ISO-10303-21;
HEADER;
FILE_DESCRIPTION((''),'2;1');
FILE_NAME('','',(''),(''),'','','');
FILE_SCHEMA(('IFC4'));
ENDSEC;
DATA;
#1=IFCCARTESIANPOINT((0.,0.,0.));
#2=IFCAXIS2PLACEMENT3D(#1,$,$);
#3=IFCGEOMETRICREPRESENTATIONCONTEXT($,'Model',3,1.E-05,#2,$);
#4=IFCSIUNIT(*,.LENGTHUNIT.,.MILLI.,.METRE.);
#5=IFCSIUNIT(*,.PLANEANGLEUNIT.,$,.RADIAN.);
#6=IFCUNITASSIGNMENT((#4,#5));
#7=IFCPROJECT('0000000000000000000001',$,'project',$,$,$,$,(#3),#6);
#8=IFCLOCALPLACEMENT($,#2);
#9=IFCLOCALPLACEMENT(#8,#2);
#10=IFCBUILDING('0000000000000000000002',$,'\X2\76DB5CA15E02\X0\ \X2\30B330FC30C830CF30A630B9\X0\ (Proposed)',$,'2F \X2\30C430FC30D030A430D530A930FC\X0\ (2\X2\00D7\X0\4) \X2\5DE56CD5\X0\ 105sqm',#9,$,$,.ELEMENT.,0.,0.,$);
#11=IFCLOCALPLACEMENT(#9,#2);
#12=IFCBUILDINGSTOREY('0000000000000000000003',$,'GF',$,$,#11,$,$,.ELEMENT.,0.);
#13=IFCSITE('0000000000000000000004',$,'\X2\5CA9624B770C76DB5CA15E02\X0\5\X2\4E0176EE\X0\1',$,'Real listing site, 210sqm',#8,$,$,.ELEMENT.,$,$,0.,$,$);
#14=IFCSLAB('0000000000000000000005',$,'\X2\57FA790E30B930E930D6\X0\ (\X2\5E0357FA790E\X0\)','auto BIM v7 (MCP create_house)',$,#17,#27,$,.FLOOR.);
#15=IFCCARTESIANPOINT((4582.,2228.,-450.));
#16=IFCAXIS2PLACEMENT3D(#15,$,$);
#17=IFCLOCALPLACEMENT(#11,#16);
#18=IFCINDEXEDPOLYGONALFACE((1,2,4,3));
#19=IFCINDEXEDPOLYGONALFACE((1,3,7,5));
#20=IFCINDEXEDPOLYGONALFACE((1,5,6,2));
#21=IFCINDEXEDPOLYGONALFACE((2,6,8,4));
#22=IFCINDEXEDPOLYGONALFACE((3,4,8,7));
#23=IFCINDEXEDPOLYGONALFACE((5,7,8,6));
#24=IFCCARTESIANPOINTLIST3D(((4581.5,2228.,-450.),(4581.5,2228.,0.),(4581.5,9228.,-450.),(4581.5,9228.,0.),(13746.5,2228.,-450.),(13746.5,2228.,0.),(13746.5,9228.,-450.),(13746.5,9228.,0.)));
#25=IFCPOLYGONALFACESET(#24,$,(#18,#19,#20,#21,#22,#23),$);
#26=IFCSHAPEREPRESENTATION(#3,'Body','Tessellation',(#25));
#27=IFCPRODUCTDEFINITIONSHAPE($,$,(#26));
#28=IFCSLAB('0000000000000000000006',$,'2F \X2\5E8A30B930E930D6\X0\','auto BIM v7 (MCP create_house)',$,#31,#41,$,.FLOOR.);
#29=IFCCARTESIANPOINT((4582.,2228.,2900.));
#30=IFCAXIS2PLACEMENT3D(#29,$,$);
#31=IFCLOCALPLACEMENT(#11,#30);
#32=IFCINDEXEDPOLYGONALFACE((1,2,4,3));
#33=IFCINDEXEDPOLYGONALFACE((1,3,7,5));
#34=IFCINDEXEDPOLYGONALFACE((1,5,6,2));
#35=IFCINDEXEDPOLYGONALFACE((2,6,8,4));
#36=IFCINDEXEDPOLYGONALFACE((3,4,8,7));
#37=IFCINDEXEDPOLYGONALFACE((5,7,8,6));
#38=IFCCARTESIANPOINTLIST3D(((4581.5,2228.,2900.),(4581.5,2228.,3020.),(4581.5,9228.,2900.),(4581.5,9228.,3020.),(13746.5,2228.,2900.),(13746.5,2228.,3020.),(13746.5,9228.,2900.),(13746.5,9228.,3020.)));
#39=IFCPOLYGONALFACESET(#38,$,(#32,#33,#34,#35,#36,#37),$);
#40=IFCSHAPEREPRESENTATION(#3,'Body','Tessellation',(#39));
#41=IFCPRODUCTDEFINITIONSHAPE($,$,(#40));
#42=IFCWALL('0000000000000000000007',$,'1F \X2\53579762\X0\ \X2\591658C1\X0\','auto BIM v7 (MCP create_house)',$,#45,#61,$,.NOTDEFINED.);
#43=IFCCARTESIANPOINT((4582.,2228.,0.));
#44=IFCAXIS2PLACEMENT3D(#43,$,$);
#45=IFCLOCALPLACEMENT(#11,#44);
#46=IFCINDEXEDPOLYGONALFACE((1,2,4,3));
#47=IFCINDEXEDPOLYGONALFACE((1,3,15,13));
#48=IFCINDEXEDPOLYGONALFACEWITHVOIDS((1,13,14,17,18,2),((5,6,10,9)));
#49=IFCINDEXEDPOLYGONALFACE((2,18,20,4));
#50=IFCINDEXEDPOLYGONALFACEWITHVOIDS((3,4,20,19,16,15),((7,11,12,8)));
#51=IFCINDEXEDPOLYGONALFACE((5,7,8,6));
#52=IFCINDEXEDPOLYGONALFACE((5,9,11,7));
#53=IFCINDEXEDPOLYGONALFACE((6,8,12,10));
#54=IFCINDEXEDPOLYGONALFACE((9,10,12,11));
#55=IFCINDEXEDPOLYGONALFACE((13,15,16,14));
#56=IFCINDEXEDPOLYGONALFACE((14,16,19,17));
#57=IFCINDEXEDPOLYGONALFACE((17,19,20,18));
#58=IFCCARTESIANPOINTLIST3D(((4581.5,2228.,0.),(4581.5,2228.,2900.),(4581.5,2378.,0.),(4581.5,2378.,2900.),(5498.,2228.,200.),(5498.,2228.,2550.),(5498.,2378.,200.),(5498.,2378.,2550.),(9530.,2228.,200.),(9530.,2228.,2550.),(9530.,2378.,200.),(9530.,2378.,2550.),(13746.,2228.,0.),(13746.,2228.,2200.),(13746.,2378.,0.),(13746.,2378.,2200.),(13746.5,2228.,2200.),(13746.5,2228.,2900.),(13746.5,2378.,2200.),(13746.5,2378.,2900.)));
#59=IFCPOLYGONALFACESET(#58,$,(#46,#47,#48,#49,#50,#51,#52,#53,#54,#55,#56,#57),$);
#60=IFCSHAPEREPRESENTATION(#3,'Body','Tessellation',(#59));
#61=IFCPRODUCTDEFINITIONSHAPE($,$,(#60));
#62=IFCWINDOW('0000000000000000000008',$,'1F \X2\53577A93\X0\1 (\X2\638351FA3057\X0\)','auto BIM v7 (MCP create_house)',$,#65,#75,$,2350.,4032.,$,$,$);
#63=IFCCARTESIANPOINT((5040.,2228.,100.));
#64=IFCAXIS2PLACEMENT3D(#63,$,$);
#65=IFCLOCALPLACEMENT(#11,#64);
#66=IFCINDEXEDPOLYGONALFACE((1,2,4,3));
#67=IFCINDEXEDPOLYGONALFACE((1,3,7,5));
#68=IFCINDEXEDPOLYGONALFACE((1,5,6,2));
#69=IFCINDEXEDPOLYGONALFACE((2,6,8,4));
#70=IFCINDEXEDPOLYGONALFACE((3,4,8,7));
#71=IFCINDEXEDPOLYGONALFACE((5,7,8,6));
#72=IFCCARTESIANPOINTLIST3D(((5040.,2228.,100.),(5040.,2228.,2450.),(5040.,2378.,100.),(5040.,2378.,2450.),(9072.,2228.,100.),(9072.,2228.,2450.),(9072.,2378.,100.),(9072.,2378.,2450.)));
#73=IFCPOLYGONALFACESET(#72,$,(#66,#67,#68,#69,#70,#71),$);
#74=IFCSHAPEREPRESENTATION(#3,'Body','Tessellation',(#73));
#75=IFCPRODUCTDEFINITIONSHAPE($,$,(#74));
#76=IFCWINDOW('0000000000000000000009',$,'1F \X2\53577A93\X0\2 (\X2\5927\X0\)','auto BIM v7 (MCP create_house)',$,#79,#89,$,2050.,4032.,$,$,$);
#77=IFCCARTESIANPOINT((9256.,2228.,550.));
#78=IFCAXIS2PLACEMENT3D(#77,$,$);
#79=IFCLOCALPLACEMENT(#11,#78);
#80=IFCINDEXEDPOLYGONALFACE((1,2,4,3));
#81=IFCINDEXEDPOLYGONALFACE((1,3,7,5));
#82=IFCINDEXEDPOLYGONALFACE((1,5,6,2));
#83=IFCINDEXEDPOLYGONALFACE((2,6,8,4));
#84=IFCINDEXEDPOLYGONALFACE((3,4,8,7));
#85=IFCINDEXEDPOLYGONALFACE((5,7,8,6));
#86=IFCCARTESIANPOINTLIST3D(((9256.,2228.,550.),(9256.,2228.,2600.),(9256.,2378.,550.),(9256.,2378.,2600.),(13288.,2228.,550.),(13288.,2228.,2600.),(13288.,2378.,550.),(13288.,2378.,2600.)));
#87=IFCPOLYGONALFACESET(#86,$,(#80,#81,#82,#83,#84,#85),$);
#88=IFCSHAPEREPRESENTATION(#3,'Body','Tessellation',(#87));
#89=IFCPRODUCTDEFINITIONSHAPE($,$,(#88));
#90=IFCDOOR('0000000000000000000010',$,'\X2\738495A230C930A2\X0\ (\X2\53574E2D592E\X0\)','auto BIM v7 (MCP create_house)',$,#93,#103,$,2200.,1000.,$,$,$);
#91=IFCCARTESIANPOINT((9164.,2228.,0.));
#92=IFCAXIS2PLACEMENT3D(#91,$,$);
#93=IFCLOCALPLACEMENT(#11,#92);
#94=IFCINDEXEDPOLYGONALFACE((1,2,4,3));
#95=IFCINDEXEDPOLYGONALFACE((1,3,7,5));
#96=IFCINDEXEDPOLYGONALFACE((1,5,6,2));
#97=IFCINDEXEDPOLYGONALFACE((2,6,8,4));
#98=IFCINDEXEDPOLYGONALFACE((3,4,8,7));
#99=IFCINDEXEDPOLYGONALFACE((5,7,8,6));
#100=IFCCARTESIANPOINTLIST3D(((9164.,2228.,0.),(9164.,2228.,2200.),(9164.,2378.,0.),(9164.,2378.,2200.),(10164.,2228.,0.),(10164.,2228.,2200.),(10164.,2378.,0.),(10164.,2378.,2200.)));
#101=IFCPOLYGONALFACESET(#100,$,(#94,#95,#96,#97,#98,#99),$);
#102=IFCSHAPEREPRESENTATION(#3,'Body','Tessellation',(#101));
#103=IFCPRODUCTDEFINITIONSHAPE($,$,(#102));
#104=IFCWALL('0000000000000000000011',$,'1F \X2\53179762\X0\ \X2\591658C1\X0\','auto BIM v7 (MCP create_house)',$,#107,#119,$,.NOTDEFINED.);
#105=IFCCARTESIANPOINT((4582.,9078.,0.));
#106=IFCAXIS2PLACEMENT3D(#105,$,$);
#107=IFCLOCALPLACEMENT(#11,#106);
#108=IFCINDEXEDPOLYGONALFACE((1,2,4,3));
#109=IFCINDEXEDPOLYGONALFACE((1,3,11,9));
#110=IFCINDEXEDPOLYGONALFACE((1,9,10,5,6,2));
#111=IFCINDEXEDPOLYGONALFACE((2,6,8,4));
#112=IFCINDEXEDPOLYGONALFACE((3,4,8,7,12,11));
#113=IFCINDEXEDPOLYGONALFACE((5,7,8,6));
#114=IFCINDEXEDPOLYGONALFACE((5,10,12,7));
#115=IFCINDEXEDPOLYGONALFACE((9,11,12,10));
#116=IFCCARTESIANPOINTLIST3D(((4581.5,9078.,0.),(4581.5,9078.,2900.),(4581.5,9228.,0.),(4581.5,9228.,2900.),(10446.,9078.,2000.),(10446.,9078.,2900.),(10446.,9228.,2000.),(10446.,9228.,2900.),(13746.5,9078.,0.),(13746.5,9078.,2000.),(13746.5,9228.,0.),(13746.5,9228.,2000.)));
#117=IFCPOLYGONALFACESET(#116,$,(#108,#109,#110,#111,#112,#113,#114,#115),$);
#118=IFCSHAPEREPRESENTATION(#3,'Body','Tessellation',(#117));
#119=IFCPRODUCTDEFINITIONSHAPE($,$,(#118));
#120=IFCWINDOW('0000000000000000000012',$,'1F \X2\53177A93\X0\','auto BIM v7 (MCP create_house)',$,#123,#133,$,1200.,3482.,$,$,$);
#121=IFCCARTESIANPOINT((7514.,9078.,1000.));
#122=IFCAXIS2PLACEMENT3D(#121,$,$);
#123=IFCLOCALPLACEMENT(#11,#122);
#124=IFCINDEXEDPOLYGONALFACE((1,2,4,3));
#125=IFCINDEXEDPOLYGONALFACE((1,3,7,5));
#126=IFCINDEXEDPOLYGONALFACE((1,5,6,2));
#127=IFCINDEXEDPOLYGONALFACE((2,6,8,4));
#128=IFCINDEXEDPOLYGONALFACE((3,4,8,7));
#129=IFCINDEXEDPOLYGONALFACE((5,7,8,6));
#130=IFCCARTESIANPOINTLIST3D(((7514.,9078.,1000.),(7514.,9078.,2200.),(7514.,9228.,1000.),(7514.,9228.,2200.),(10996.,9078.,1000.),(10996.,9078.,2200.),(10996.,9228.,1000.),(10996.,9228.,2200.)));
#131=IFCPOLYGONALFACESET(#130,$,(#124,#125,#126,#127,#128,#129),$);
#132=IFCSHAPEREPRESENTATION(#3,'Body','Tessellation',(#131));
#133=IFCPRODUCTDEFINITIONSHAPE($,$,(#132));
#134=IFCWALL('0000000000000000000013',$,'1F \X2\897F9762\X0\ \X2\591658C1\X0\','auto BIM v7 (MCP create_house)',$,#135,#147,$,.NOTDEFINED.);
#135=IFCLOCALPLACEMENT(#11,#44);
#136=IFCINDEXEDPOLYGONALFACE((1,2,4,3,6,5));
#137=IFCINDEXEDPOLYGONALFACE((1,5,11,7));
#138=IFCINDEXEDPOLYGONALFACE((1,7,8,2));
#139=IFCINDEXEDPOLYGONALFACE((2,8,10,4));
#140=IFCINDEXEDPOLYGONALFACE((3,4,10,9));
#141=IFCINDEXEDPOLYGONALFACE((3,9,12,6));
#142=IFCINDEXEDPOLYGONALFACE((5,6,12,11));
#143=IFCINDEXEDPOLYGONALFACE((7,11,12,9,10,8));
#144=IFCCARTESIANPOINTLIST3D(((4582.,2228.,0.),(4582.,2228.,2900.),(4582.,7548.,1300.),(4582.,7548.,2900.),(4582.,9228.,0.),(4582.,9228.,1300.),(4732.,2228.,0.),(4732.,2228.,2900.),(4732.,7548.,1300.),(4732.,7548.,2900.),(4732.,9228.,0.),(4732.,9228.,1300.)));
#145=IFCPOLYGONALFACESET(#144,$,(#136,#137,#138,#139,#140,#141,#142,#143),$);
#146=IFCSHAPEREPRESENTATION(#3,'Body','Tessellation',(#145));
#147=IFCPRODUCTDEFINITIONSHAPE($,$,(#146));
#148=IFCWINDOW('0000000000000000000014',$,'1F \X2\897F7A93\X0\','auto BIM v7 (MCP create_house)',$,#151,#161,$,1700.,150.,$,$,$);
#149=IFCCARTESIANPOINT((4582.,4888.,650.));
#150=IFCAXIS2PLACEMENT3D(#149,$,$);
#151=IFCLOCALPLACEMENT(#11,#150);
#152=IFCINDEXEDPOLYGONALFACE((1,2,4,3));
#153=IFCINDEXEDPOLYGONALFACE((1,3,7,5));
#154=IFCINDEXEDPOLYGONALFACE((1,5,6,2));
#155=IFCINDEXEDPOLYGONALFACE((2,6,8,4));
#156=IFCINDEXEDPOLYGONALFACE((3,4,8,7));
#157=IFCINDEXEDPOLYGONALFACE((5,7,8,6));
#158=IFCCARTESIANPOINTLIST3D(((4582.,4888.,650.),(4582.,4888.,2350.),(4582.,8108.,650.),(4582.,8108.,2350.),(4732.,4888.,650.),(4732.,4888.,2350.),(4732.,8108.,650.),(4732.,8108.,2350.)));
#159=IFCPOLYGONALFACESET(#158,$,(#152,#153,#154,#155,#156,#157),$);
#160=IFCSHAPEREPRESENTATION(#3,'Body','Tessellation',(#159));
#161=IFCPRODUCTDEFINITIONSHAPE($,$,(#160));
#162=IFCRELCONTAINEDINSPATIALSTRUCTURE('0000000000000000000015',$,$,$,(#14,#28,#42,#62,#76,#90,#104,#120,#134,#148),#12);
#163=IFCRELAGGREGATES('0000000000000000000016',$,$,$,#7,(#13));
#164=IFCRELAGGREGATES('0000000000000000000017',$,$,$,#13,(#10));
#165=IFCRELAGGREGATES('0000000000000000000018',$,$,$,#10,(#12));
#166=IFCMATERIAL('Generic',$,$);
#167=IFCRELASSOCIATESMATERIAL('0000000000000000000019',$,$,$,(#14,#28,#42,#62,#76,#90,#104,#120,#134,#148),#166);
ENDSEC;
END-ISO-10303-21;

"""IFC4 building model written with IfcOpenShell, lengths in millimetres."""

from ifc_helpers import new_model, si_unit, frame, frame_2d, origin, place, context, project, spatial, rectangle, extrude, material, element, fill, save


model = new_model("IFC4")

# Units and contexts
model_context = context("Model", 3, precision=1e-05, world=origin())
ifc_project = project(units=[si_unit("LENGTHUNIT", "METRE", prefix="MILLI"), si_unit("PLANEANGLEUNIT", "RADIAN")], contexts=[model_context])

# Site, building, storey
site_placement = place(None, origin())
site = spatial("IfcSite", under=ifc_project, at=site_placement, Name="岩手県盛岡市5丁目1", ObjectType="Real listing site, 210sqm", CompositionType="ELEMENT", RefElevation=0.0)
building_placement = place(site_placement, origin())
building = spatial("IfcBuilding", under=site, at=building_placement, Name="盛岡市 コートハウス (Proposed)", ObjectType="2F ツーバイフォー (2×4) 工法 105sqm", CompositionType="ELEMENT", ElevationOfRefHeight=0.0, ElevationOfTerrain=0.0)
storey_placement = place(building_placement, origin())
storey = spatial("IfcBuildingStorey", under=building, at=storey_placement, Name="GF", CompositionType="ELEMENT", Elevation=0.0)

# Slabs
ifc_material = material(Name="Generic")
slab_1_placement = place(storey_placement, frame((4582.0, 2228.0, -450.0)))
element("IfcSlab", 1, at=slab_1_placement, inside=storey, material=ifc_material, Name="基礎スラブ (布基礎)", Description="auto BIM v7 (MCP create_house)", PredefinedType="FLOOR", context=model_context, shape_type="SweptSolid", body=[
    extrude(rectangle(XDim=9165.0, YDim=7000.0, at=frame_2d((4582.0, 3500.0))), frame((4582.0, 2228.0, -450.0)), (0.0, 0.0, 1.0), 450.0),
])
slab_2_placement = place(storey_placement, frame((4582.0, 2228.0, 2900.0)))
element("IfcSlab", 2, at=slab_2_placement, inside=storey, material=ifc_material, Name="2F 床スラブ", Description="auto BIM v7 (MCP create_house)", PredefinedType="FLOOR", context=model_context, shape_type="SweptSolid", body=[
    extrude(rectangle(XDim=9165.0, YDim=7000.0, at=frame_2d((4582.0, 3500.0))), frame((4582.0, 2228.0, 2900.0)), (0.0, 0.0, 1.0), 120.0),
])

# Wall, openings, windows, door
wall_1_placement = place(storey_placement, frame((4582.0, 2228.0, 0.0)))
wall_1 = element("IfcWall", 3, at=wall_1_placement, inside=storey, material=ifc_material, Name="1F 南面 外壁", Description="auto BIM v7 (MCP create_house)", PredefinedType="NOTDEFINED", context=model_context, shape_type="SweptSolid", body=[
    extrude(rectangle(XDim=9165.0, YDim=150.0, at=frame_2d((4582.0, 75.0))), frame((4582.0, 2228.0, 0.0)), (0.0, 0.0, 1.0), 2900.0),
])
opening_1_placement = place(storey_placement, frame((5040.0, 2228.0, 100.0)))
opening_1 = element("IfcOpeningElement", 4, at=opening_1_placement, cuts=wall_1, PredefinedType="NOTDEFINED", context=model_context, shape_type="SweptSolid", body=[
    extrude(rectangle(XDim=4032.0, YDim=150.0, at=frame_2d((2016.0, 75.0))), frame((5040.0, 2228.0, 100.0)), (0.0, 0.0, 1.0), 2350.0),
])
opening_2_placement = place(storey_placement, frame((9256.0, 2228.0, 550.0)))
opening_2 = element("IfcOpeningElement", 5, at=opening_2_placement, cuts=wall_1, PredefinedType="NOTDEFINED", context=model_context, shape_type="SweptSolid", body=[
    extrude(rectangle(XDim=4032.0, YDim=150.0, at=frame_2d((2016.0, 75.0))), frame((9256.0, 2228.0, 550.0)), (0.0, 0.0, 1.0), 2050.0),
])
opening_3_placement = place(storey_placement, frame((9164.0, 2228.0, 0.0)))
opening_3 = element("IfcOpeningElement", 6, at=opening_3_placement, cuts=wall_1, PredefinedType="NOTDEFINED", context=model_context, shape_type="SweptSolid", body=[
    extrude(rectangle(XDim=1000.0, YDim=150.0, at=frame_2d((500.0, 75.0))), frame((9164.0, 2228.0, 0.0)), (0.0, 0.0, 1.0), 2200.0),
])
window_1_placement = place(storey_placement, frame((5040.0, 2228.0, 100.0)))
window_1 = element("IfcWindow", 7, at=window_1_placement, inside=storey, material=ifc_material, Name="1F 南窓1 (掃出し)", Description="auto BIM v7 (MCP create_house)", OverallHeight=2350.0, OverallWidth=4032.0, context=model_context, shape_type="SweptSolid", body=[
    extrude(rectangle(XDim=4032.0, YDim=150.0, at=frame_2d((2016.0, 75.0))), frame((5040.0, 2228.0, 100.0)), (0.0, 0.0, 1.0), 2350.0),
])
fill(opening_1, window_1)
window_2_placement = place(storey_placement, frame((9256.0, 2228.0, 550.0)))
window_2 = element("IfcWindow", 8, at=window_2_placement, inside=storey, material=ifc_material, Name="1F 南窓2 (大)", Description="auto BIM v7 (MCP create_house)", OverallHeight=2050.0, OverallWidth=4032.0, context=model_context, shape_type="SweptSolid", body=[
    extrude(rectangle(XDim=4032.0, YDim=150.0, at=frame_2d((2016.0, 75.0))), frame((9256.0, 2228.0, 550.0)), (0.0, 0.0, 1.0), 2050.0),
])
fill(opening_2, window_2)
door_placement = place(storey_placement, frame((9164.0, 2228.0, 0.0)))
door = element("IfcDoor", 9, at=door_placement, inside=storey, material=ifc_material, Name="玄関ドア (南中央)", Description="auto BIM v7 (MCP create_house)", OverallHeight=2200.0, OverallWidth=1000.0, context=model_context, shape_type="SweptSolid", body=[
    extrude(rectangle(XDim=1000.0, YDim=150.0, at=frame_2d((500.0, 75.0))), frame((9164.0, 2228.0, 0.0)), (0.0, 0.0, 1.0), 2200.0),
])
fill(opening_3, door)

# Walls, openings, windows
wall_2_placement = place(storey_placement, frame((4582.0, 9078.0, 0.0)))
wall_2 = element("IfcWall", 10, at=wall_2_placement, inside=storey, material=ifc_material, Name="1F 北面 外壁", Description="auto BIM v7 (MCP create_house)", PredefinedType="NOTDEFINED", context=model_context, shape_type="SweptSolid", body=[
    extrude(rectangle(XDim=9165.0, YDim=150.0, at=frame_2d((4582.0, 75.0))), frame((4582.0, 9078.0, 0.0)), (0.0, 0.0, 1.0), 2900.0),
])
opening_4_placement = place(storey_placement, frame((7514.0, 9078.0, 1000.0)))
opening_4 = element("IfcOpeningElement", 11, at=opening_4_placement, cuts=wall_2, PredefinedType="NOTDEFINED", context=model_context, shape_type="SweptSolid", body=[
    extrude(rectangle(XDim=3482.0, YDim=150.0, at=frame_2d((1741.0, 75.0))), frame((7514.0, 9078.0, 1000.0)), (0.0, 0.0, 1.0), 1200.0),
])
window_3_placement = place(storey_placement, frame((7514.0, 9078.0, 1000.0)))
window_3 = element("IfcWindow", 12, at=window_3_placement, inside=storey, material=ifc_material, Name="1F 北窓", Description="auto BIM v7 (MCP create_house)", OverallHeight=1200.0, OverallWidth=3482.0, context=model_context, shape_type="SweptSolid", body=[
    extrude(rectangle(XDim=3482.0, YDim=150.0, at=frame_2d((1741.0, 75.0))), frame((7514.0, 9078.0, 1000.0)), (0.0, 0.0, 1.0), 1200.0),
])
fill(opening_4, window_3)
wall_3_placement = place(storey_placement, frame((4582.0, 2228.0, 0.0)))
wall_3 = element("IfcWall", 13, at=wall_3_placement, inside=storey, material=ifc_material, Name="1F 西面 外壁", Description="auto BIM v7 (MCP create_house)", PredefinedType="NOTDEFINED", context=model_context, shape_type="SweptSolid", body=[
    extrude(rectangle(XDim=150.0, YDim=7000.0, at=frame_2d((75.0, 3500.0))), frame((4582.0, 2228.0, 0.0)), (0.0, 0.0, 1.0), 2900.0),
])
opening_5_placement = place(storey_placement, frame((4582.0, 4888.0, 650.0)))
opening_5 = element("IfcOpeningElement", 14, at=opening_5_placement, cuts=wall_3, PredefinedType="NOTDEFINED", context=model_context, shape_type="SweptSolid", body=[
    extrude(rectangle(XDim=150.0, YDim=3220.0, at=frame_2d((75.0, 1610.0))), frame((4582.0, 4888.0, 650.0)), (0.0, 0.0, 1.0), 1700.0),
])
window_4_placement = place(storey_placement, frame((4582.0, 4888.0, 650.0)))
window_4 = element("IfcWindow", 15, at=window_4_placement, inside=storey, material=ifc_material, Name="1F 西窓", Description="auto BIM v7 (MCP create_house)", OverallHeight=1700.0, OverallWidth=150.0, context=model_context, shape_type="SweptSolid", body=[
    extrude(rectangle(XDim=150.0, YDim=3220.0, at=frame_2d((75.0, 1610.0))), frame((4582.0, 4888.0, 650.0)), (0.0, 0.0, 1.0), 1700.0),
])
fill(opening_5, window_4)

save(model, "model.ifc")
